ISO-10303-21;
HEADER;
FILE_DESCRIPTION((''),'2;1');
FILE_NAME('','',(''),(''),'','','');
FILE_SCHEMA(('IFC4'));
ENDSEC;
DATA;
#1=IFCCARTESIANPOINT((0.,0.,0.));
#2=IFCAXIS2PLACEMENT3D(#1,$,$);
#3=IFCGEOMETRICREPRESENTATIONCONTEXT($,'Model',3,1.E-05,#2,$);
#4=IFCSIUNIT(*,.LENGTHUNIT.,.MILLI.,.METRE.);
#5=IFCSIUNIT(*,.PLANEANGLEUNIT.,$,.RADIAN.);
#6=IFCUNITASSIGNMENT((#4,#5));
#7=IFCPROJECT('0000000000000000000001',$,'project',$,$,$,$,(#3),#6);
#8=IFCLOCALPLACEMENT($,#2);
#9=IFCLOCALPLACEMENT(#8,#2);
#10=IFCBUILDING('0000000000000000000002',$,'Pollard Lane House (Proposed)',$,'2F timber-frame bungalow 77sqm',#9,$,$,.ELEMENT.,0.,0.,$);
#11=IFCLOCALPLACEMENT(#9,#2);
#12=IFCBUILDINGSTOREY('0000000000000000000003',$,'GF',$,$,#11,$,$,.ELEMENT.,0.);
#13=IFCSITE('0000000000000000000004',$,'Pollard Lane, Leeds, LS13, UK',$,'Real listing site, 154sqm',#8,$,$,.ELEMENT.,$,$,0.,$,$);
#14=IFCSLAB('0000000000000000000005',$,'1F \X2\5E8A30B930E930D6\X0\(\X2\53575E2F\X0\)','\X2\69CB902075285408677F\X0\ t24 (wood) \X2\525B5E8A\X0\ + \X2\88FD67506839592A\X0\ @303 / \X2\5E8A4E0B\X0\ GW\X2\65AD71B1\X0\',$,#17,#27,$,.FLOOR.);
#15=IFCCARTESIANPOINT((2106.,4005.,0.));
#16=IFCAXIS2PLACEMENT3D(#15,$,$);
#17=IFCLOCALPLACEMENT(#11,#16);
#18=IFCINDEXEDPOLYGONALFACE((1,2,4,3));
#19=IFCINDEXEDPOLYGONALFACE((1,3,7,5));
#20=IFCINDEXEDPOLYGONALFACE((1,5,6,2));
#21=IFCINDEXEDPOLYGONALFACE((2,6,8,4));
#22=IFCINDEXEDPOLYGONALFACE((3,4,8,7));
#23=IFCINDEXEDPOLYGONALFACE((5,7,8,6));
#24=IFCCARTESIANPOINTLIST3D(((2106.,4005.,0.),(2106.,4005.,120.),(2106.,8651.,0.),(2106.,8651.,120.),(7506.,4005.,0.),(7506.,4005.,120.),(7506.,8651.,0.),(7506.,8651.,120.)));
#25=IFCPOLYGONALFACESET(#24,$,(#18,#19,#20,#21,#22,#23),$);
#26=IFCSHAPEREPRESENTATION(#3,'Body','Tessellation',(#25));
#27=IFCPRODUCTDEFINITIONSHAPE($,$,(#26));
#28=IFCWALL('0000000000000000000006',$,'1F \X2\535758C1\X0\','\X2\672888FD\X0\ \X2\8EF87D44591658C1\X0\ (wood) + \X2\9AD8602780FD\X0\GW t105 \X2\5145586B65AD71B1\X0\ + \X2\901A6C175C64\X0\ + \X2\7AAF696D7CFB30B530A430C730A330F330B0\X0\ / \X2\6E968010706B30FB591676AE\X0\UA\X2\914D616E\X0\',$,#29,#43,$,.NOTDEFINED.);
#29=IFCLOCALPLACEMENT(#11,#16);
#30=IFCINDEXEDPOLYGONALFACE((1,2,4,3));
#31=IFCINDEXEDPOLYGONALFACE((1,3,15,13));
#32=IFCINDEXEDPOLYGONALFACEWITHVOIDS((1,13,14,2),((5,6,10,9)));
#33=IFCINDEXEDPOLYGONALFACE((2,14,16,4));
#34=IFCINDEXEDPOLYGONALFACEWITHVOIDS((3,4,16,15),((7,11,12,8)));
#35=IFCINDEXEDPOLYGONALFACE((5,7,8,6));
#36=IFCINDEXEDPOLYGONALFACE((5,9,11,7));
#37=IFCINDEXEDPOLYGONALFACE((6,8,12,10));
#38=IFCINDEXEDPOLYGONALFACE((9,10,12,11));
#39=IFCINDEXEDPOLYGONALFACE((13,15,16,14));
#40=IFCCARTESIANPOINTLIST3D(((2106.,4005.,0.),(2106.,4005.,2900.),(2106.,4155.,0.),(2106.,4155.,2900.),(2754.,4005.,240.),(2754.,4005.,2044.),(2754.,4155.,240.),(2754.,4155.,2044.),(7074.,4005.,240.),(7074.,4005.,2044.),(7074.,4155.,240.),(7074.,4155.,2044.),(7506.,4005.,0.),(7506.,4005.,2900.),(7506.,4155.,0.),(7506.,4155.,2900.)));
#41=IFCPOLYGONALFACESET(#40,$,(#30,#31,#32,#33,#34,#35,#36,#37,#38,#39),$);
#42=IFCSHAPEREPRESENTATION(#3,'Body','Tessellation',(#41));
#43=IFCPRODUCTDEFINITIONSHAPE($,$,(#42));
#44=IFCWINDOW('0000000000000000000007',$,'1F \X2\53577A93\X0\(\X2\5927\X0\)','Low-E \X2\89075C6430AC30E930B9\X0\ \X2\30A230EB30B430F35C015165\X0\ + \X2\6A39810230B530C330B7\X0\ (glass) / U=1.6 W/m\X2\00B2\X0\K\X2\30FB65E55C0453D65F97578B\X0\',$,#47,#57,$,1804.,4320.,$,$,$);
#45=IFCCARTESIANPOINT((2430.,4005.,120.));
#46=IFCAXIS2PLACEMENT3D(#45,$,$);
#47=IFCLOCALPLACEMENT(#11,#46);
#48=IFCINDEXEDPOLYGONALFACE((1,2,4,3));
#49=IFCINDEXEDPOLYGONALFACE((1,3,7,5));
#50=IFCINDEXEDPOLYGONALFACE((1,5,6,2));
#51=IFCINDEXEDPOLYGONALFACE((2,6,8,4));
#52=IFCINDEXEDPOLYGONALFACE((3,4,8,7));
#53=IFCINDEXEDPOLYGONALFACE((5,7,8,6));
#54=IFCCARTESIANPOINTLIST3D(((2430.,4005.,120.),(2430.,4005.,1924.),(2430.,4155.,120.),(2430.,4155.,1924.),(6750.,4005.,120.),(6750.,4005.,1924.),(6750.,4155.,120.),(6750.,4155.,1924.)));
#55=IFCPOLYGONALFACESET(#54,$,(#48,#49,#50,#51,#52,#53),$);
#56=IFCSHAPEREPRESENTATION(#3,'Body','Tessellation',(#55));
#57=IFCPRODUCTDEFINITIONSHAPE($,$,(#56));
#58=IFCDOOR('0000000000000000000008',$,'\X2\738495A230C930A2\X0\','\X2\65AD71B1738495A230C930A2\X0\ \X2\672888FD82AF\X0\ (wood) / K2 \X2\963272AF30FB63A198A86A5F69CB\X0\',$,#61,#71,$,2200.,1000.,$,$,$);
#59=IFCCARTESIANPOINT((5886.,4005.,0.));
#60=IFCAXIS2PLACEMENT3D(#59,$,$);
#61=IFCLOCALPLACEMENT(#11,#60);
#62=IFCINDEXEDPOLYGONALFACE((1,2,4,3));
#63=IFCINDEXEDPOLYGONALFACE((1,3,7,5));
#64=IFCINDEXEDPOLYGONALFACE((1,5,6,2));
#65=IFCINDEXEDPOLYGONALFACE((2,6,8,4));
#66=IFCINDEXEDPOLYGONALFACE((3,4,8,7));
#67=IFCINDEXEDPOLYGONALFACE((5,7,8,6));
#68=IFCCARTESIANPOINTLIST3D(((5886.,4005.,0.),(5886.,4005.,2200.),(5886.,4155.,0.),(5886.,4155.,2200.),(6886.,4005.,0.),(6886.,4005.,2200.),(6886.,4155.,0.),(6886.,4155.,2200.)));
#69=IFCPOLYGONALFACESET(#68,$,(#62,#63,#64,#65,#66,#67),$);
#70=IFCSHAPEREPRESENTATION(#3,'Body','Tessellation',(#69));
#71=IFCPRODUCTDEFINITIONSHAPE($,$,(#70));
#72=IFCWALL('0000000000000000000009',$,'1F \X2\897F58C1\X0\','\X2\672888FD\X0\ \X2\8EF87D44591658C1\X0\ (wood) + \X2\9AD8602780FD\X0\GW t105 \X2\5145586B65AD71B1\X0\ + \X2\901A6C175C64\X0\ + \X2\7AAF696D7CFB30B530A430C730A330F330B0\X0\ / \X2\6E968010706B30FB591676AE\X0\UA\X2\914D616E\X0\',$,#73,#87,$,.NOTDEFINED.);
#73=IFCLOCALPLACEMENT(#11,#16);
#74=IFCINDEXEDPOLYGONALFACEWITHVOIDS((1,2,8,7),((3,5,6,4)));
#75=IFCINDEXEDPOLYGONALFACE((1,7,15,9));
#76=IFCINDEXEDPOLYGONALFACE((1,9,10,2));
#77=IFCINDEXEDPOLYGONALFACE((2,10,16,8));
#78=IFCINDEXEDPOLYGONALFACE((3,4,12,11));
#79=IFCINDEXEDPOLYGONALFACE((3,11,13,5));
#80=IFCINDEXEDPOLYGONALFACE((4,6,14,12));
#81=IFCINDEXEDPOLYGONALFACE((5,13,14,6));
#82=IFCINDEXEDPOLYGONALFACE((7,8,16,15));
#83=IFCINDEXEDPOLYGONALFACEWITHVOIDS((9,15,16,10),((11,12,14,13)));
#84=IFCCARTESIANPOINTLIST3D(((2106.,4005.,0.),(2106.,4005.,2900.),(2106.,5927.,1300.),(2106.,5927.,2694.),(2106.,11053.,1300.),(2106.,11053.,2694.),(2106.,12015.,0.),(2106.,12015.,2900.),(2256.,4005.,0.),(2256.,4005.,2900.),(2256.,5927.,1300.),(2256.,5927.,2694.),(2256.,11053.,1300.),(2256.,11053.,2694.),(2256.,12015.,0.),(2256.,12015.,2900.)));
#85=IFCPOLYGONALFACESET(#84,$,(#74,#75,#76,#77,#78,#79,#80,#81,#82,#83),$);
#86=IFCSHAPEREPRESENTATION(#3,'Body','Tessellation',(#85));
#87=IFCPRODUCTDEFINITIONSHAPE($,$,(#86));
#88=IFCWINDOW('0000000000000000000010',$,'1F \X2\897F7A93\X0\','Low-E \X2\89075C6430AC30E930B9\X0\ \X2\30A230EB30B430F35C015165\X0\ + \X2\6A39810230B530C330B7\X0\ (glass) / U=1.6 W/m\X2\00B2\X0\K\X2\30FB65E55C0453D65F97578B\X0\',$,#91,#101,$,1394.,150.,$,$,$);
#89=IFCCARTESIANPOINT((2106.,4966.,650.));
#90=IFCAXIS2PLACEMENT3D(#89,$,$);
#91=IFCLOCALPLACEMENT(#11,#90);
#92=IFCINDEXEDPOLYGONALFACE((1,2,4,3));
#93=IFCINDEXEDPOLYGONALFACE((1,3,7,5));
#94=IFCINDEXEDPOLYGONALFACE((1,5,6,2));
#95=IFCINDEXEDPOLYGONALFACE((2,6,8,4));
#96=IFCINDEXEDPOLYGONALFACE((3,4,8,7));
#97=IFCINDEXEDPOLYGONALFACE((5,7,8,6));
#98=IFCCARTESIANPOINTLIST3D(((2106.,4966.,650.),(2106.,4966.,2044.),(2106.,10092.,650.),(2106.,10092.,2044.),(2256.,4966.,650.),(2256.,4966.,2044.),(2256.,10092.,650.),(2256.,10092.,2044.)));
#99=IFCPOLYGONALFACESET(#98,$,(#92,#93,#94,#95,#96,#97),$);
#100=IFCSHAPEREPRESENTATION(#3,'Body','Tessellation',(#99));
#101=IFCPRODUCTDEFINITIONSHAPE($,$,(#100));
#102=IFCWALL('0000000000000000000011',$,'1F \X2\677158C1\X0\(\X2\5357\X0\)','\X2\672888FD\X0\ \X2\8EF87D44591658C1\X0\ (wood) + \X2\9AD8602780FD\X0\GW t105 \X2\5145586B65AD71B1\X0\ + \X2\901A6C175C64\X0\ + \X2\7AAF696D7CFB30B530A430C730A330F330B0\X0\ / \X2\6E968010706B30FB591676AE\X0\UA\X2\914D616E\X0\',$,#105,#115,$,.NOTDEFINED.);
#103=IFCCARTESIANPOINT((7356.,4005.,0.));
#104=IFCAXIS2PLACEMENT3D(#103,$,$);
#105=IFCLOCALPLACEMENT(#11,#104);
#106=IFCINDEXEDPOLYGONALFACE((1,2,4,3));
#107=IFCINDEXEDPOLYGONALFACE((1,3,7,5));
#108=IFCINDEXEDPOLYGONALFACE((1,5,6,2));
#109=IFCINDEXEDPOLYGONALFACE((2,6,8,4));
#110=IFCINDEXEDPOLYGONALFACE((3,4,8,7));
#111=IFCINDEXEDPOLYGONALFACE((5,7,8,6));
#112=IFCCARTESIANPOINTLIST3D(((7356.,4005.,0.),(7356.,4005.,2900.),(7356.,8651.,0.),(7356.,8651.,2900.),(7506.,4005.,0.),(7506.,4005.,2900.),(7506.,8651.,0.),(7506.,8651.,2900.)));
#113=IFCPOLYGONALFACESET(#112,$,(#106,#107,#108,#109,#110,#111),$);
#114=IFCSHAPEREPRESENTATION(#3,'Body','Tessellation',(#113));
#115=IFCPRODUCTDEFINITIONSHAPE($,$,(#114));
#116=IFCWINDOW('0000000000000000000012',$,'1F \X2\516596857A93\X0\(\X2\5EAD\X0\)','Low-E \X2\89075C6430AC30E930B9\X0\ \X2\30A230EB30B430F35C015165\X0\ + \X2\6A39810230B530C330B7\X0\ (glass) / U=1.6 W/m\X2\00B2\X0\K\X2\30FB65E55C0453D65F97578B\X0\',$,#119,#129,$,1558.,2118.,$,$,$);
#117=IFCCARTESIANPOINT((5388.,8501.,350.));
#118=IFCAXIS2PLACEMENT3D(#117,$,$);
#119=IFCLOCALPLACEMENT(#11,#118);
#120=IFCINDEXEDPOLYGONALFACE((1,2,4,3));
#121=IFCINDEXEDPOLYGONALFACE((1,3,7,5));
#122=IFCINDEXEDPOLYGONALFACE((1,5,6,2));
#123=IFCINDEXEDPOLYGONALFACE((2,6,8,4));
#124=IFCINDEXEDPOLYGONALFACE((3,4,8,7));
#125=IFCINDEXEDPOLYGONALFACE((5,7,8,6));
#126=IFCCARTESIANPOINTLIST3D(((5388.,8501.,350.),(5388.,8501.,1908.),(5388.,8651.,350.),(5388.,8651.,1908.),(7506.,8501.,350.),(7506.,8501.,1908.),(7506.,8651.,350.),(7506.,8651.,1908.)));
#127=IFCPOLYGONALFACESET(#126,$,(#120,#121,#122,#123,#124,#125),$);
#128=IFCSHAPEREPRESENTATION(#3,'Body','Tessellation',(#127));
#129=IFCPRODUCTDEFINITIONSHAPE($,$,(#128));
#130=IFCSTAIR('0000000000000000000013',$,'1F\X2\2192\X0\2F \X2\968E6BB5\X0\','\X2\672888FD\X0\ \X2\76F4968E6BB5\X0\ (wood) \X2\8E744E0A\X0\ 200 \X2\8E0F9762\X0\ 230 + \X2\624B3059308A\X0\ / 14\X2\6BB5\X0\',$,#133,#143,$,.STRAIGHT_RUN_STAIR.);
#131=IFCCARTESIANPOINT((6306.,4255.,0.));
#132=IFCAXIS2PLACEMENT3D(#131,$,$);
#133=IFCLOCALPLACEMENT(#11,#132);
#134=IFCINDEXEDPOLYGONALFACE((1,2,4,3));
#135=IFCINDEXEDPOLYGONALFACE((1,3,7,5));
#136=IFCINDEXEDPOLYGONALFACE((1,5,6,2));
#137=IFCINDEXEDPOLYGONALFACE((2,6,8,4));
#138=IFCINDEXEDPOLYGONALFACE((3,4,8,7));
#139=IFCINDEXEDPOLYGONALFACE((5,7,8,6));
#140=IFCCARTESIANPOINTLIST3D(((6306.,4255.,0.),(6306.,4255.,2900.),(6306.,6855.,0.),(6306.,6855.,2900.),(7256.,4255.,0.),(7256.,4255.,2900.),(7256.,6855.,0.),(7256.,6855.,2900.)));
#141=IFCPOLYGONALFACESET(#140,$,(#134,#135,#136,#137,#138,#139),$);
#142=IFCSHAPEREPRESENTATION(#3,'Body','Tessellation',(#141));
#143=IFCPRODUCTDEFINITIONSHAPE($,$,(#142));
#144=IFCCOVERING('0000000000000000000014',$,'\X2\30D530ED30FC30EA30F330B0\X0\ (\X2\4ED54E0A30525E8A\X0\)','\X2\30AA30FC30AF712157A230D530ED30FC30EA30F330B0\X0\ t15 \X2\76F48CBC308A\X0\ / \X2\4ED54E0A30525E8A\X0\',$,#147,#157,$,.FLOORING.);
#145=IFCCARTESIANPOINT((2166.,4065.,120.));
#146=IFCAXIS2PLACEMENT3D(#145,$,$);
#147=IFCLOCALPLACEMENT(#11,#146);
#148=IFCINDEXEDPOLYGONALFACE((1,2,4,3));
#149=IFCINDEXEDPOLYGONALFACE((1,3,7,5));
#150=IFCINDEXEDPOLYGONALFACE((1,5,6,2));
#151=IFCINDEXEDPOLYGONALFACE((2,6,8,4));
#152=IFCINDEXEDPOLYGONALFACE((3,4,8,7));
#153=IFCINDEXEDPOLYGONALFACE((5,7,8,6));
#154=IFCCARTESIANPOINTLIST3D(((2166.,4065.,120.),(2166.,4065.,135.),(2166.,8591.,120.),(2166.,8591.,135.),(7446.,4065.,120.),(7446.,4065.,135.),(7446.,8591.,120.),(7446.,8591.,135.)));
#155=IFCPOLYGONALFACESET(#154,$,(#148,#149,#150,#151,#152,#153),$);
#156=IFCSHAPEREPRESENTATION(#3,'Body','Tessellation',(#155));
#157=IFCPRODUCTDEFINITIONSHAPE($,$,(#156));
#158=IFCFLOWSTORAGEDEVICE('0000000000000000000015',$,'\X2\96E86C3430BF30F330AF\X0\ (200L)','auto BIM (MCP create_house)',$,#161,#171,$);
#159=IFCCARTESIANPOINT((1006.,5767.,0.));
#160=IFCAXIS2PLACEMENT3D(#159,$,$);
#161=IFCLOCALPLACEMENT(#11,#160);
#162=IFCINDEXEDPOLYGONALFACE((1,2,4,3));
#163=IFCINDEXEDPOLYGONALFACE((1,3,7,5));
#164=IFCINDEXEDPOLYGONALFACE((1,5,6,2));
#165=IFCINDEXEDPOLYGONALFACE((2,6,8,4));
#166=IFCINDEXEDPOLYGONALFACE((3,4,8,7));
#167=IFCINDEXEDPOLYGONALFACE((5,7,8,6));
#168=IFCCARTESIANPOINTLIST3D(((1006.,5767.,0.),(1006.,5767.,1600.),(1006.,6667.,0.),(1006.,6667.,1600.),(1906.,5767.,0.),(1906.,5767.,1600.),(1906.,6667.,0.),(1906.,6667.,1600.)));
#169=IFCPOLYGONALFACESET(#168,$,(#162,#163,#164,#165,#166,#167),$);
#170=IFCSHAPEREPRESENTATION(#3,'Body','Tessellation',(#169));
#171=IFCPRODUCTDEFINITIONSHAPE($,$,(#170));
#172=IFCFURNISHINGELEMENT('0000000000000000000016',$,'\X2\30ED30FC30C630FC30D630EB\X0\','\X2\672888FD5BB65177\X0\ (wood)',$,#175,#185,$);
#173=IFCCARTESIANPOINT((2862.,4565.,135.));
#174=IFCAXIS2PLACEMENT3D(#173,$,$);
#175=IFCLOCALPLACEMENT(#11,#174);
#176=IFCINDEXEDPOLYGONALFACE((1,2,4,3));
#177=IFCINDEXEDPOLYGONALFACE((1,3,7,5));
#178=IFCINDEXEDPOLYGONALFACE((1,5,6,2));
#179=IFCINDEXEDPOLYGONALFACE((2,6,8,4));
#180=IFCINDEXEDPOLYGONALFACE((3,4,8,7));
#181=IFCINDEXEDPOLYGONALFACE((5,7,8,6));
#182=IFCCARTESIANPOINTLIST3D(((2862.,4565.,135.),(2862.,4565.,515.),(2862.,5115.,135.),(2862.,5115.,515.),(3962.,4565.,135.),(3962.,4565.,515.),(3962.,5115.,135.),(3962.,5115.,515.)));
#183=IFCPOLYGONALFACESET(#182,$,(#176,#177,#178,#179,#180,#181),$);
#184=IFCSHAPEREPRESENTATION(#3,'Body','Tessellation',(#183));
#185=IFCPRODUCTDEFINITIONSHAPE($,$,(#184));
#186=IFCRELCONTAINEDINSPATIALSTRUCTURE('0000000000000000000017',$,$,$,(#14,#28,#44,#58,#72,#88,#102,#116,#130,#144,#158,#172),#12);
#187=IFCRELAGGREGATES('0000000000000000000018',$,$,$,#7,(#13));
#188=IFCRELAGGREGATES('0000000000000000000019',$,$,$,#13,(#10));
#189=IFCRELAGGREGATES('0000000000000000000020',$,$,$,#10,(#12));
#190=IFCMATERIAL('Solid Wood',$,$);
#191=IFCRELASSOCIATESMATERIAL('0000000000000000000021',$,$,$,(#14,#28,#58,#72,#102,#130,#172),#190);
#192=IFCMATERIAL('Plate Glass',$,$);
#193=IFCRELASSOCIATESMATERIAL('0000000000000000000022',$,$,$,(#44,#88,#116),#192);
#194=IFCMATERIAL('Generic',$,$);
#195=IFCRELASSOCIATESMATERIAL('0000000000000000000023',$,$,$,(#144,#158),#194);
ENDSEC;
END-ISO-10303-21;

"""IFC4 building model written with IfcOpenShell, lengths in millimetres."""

from ifc_helpers import new_model, si_unit, frame, frame_2d, origin, place, context, project, spatial, rectangle, extrude, material, element, fill, save


model = new_model("IFC4")

# Units and contexts
model_context = context("Model", 3, precision=1e-05, world=origin())
ifc_project = project(units=[si_unit("LENGTHUNIT", "METRE", prefix="MILLI"), si_unit("PLANEANGLEUNIT", "RADIAN")], contexts=[model_context])

# Site, building, storey
site_placement = place(None, origin())
site = spatial("IfcSite", under=ifc_project, at=site_placement, Name="Pollard Lane, Leeds, LS13, UK", ObjectType="Real listing site, 154sqm", CompositionType="ELEMENT", RefElevation=0.0)
building_placement = place(site_placement, origin())
building = spatial("IfcBuilding", under=site, at=building_placement, Name="Pollard Lane House (Proposed)", ObjectType="2F timber-frame bungalow 77sqm", CompositionType="ELEMENT", ElevationOfRefHeight=0.0, ElevationOfTerrain=0.0)
storey_placement = place(building_placement, origin())
storey = spatial("IfcBuildingStorey", under=building, at=storey_placement, Name="GF", CompositionType="ELEMENT", Elevation=0.0)

# Slab
ifc_material_1 = material(Name="Solid Wood")
slab_1_placement = place(storey_placement, frame((2106.0, 4005.0, 0.0)))
element("IfcSlab", 1, at=slab_1_placement, inside=storey, material=ifc_material_1, Name="1F 床スラブ(南帯)", Description="構造用合板 t24 (wood) 剛床 + 製材根太 @303 / 床下 GW断熱", PredefinedType="FLOOR", context=model_context, shape_type="SweptSolid", body=[
    extrude(rectangle(XDim=5400.0, YDim=4646.0, at=frame_2d((2700.0, 2323.0))), frame((2106.0, 4005.0, 0.0)), (0.0, 0.0, 1.0), 120.0),
])

# Wall, openings, window, door
wall_1_placement = place(storey_placement, frame((2106.0, 4005.0, 0.0)))
wall_1 = element("IfcWall", 2, at=wall_1_placement, inside=storey, material=ifc_material_1, Name="1F 南壁", Description="木製 軸組外壁 (wood) + 高性能GW t105 充填断熱 + 通気層 + 窯業系サイディング / 準耐火・外皮UA配慮", PredefinedType="NOTDEFINED", context=model_context, shape_type="SweptSolid", body=[
    extrude(rectangle(XDim=5400.0, YDim=150.0, at=frame_2d((2700.0, 75.0))), frame((2106.0, 4005.0, 0.0)), (0.0, 0.0, 1.0), 2900.0),
])
opening_1_placement = place(storey_placement, frame((2430.0, 4005.0, 120.0)))
opening_1 = element("IfcOpeningElement", 3, at=opening_1_placement, cuts=wall_1, PredefinedType="NOTDEFINED", context=model_context, shape_type="SweptSolid", body=[
    extrude(rectangle(XDim=4320.0, YDim=150.0, at=frame_2d((2160.0, 75.0))), frame((2430.0, 4005.0, 120.0)), (0.0, 0.0, 1.0), 1804.0),
])
opening_2_placement = place(storey_placement, frame((5886.0, 4005.0, 0.0)))
opening_2 = element("IfcOpeningElement", 4, at=opening_2_placement, cuts=wall_1, PredefinedType="NOTDEFINED", context=model_context, shape_type="SweptSolid", body=[
    extrude(rectangle(XDim=1000.0, YDim=150.0, at=frame_2d((500.0, 75.0))), frame((5886.0, 4005.0, 0.0)), (0.0, 0.0, 1.0), 2200.0),
])
ifc_material_2 = material(Name="Plate Glass")
window_1_placement = place(storey_placement, frame((2430.0, 4005.0, 120.0)))
window_1 = element("IfcWindow", 5, at=window_1_placement, inside=storey, material=ifc_material_2, Name="1F 南窓(大)", Description="Low-E 複層ガラス アルゴン封入 + 樹脂サッシ (glass) / U=1.6 W/m²K・日射取得型", OverallHeight=1804.0, OverallWidth=4320.0, context=model_context, shape_type="SweptSolid", body=[
    extrude(rectangle(XDim=4320.0, YDim=150.0, at=frame_2d((2160.0, 75.0))), frame((2430.0, 4005.0, 120.0)), (0.0, 0.0, 1.0), 1804.0),
])
fill(opening_1, window_1)
door_1_placement = place(storey_placement, frame((5886.0, 4005.0, 0.0)))
door_1 = element("IfcDoor", 6, at=door_1_placement, inside=storey, material=ifc_material_1, Name="玄関ドア", Description="断熱玄関ドア 木製芯 (wood) / K2 防犯・採風機構", OverallHeight=2200.0, OverallWidth=1000.0, context=model_context, shape_type="SweptSolid", body=[
    extrude(rectangle(XDim=1000.0, YDim=150.0, at=frame_2d((500.0, 75.0))), frame((5886.0, 4005.0, 0.0)), (0.0, 0.0, 1.0), 2200.0),
])
fill(opening_2, door_1)

# Walls, openings, windows
wall_2_placement = place(storey_placement, frame((2106.0, 4005.0, 0.0)))
wall_2 = element("IfcWall", 7, at=wall_2_placement, inside=storey, material=ifc_material_1, Name="1F 西壁", Description="木製 軸組外壁 (wood) + 高性能GW t105 充填断熱 + 通気層 + 窯業系サイディング / 準耐火・外皮UA配慮", PredefinedType="NOTDEFINED", context=model_context, shape_type="SweptSolid", body=[
    extrude(rectangle(XDim=150.0, YDim=8010.0, at=frame_2d((75.0, 4005.0))), frame((2106.0, 4005.0, 0.0)), (0.0, 0.0, 1.0), 2900.0),
])
opening_3_placement = place(storey_placement, frame((2106.0, 4966.0, 650.0)))
opening_3 = element("IfcOpeningElement", 8, at=opening_3_placement, cuts=wall_2, PredefinedType="NOTDEFINED", context=model_context, shape_type="SweptSolid", body=[
    extrude(rectangle(XDim=150.0, YDim=5126.0, at=frame_2d((75.0, 2563.0))), frame((2106.0, 4966.0, 650.0)), (0.0, 0.0, 1.0), 1394.0),
])
window_2_placement = place(storey_placement, frame((2106.0, 4966.0, 650.0)))
window_2 = element("IfcWindow", 9, at=window_2_placement, inside=storey, material=ifc_material_2, Name="1F 西窓", Description="Low-E 複層ガラス アルゴン封入 + 樹脂サッシ (glass) / U=1.6 W/m²K・日射取得型", OverallHeight=1394.0, OverallWidth=150.0, context=model_context, shape_type="SweptSolid", body=[
    extrude(rectangle(XDim=150.0, YDim=5126.0, at=frame_2d((75.0, 2563.0))), frame((2106.0, 4966.0, 650.0)), (0.0, 0.0, 1.0), 1394.0),
])
fill(opening_3, window_2)
wall_3_placement = place(storey_placement, frame((7356.0, 4005.0, 0.0)))
wall_3 = element("IfcWall", 10, at=wall_3_placement, inside=storey, material=ifc_material_1, Name="1F 東壁(南)", Description="木製 軸組外壁 (wood) + 高性能GW t105 充填断熱 + 通気層 + 窯業系サイディング / 準耐火・外皮UA配慮", PredefinedType="NOTDEFINED", context=model_context, shape_type="SweptSolid", body=[
    extrude(rectangle(XDim=150.0, YDim=4646.0, at=frame_2d((75.0, 2323.0))), frame((7356.0, 4005.0, 0.0)), (0.0, 0.0, 1.0), 2900.0),
])
opening_4_placement = place(storey_placement, frame((5388.0, 8501.0, 350.0)))
opening_4 = element("IfcOpeningElement", 11, at=opening_4_placement, cuts=wall_3, PredefinedType="NOTDEFINED", context=model_context, shape_type="SweptSolid", body=[
    extrude(rectangle(XDim=2118.0, YDim=150.0, at=frame_2d((1059.0, 75.0))), frame((5388.0, 8501.0, 350.0)), (0.0, 0.0, 1.0), 1558.0),
])
window_3_placement = place(storey_placement, frame((5388.0, 8501.0, 350.0)))
window_3 = element("IfcWindow", 12, at=window_3_placement, inside=storey, material=ifc_material_2, Name="1F 入隅窓(庭)", Description="Low-E 複層ガラス アルゴン封入 + 樹脂サッシ (glass) / U=1.6 W/m²K・日射取得型", OverallHeight=1558.0, OverallWidth=2118.0, context=model_context, shape_type="SweptSolid", body=[
    extrude(rectangle(XDim=2118.0, YDim=150.0, at=frame_2d((1059.0, 75.0))), frame((5388.0, 8501.0, 350.0)), (0.0, 0.0, 1.0), 1558.0),
])
fill(opening_4, window_3)

# Stair
stair_placement = place(storey_placement, frame((6306.0, 4255.0, 0.0)))
element("IfcStair", 13, at=stair_placement, inside=storey, material=ifc_material_1, Name="1F→2F 階段", Description="木製 直階段 (wood) 蹴上 200 踏面 230 + 手すり / 14段", PredefinedType="STRAIGHT_RUN_STAIR", context=model_context, shape_type="SweptSolid", body=[
    extrude(rectangle(XDim=950.0, YDim=2600.0, at=frame_2d((475.0, 1300.0))), frame((6306.0, 4255.0, 0.0)), (0.0, 0.0, 1.0), 2900.0),
])

# Covering
ifc_material_3 = material(Name="Generic")
covering_placement = place(storey_placement, frame((2166.0, 4065.0, 120.0)))
element("IfcCovering", 14, at=covering_placement, inside=storey, material=ifc_material_3, Name="フローリング (仕上げ床)", Description="オーク無垢フローリング t15 直貼り / 仕上げ床", PredefinedType="FLOORING", context=model_context, shape_type="SweptSolid", body=[
    extrude(rectangle(XDim=5280.0, YDim=4526.0, at=frame_2d((2640.0, 2263.0))), frame((2166.0, 4065.0, 120.0)), (0.0, 0.0, 1.0), 15.0),
])

# Flow storage device
flow_storage_device_placement = place(storey_placement, frame((1006.0, 5767.0, 0.0)))
element("IfcFlowStorageDevice", 15, at=flow_storage_device_placement, inside=storey, material=ifc_material_3, Name="雨水タンク (200L)", Description="auto BIM (MCP create_house)", context=model_context, shape_type="SweptSolid", body=[
    extrude(rectangle(XDim=900.0, YDim=900.0, at=frame_2d((450.0, 450.0))), frame((1006.0, 5767.0, 0.0)), (0.0, 0.0, 1.0), 1600.0),
])

# Furnishing element
furnishing_1_placement = place(storey_placement, frame((2862.0, 4565.0, 135.0)))
element("IfcFurnishingElement", 16, at=furnishing_1_placement, inside=storey, material=ifc_material_1, Name="ローテーブル", Description="木製家具 (wood)", context=model_context, shape_type="SweptSolid", body=[
    extrude(rectangle(XDim=1100.0, YDim=550.0, at=frame_2d((550.0, 275.0))), frame((2862.0, 4565.0, 135.0)), (0.0, 0.0, 1.0), 380.0),
])

save(model, "model.ifc")
